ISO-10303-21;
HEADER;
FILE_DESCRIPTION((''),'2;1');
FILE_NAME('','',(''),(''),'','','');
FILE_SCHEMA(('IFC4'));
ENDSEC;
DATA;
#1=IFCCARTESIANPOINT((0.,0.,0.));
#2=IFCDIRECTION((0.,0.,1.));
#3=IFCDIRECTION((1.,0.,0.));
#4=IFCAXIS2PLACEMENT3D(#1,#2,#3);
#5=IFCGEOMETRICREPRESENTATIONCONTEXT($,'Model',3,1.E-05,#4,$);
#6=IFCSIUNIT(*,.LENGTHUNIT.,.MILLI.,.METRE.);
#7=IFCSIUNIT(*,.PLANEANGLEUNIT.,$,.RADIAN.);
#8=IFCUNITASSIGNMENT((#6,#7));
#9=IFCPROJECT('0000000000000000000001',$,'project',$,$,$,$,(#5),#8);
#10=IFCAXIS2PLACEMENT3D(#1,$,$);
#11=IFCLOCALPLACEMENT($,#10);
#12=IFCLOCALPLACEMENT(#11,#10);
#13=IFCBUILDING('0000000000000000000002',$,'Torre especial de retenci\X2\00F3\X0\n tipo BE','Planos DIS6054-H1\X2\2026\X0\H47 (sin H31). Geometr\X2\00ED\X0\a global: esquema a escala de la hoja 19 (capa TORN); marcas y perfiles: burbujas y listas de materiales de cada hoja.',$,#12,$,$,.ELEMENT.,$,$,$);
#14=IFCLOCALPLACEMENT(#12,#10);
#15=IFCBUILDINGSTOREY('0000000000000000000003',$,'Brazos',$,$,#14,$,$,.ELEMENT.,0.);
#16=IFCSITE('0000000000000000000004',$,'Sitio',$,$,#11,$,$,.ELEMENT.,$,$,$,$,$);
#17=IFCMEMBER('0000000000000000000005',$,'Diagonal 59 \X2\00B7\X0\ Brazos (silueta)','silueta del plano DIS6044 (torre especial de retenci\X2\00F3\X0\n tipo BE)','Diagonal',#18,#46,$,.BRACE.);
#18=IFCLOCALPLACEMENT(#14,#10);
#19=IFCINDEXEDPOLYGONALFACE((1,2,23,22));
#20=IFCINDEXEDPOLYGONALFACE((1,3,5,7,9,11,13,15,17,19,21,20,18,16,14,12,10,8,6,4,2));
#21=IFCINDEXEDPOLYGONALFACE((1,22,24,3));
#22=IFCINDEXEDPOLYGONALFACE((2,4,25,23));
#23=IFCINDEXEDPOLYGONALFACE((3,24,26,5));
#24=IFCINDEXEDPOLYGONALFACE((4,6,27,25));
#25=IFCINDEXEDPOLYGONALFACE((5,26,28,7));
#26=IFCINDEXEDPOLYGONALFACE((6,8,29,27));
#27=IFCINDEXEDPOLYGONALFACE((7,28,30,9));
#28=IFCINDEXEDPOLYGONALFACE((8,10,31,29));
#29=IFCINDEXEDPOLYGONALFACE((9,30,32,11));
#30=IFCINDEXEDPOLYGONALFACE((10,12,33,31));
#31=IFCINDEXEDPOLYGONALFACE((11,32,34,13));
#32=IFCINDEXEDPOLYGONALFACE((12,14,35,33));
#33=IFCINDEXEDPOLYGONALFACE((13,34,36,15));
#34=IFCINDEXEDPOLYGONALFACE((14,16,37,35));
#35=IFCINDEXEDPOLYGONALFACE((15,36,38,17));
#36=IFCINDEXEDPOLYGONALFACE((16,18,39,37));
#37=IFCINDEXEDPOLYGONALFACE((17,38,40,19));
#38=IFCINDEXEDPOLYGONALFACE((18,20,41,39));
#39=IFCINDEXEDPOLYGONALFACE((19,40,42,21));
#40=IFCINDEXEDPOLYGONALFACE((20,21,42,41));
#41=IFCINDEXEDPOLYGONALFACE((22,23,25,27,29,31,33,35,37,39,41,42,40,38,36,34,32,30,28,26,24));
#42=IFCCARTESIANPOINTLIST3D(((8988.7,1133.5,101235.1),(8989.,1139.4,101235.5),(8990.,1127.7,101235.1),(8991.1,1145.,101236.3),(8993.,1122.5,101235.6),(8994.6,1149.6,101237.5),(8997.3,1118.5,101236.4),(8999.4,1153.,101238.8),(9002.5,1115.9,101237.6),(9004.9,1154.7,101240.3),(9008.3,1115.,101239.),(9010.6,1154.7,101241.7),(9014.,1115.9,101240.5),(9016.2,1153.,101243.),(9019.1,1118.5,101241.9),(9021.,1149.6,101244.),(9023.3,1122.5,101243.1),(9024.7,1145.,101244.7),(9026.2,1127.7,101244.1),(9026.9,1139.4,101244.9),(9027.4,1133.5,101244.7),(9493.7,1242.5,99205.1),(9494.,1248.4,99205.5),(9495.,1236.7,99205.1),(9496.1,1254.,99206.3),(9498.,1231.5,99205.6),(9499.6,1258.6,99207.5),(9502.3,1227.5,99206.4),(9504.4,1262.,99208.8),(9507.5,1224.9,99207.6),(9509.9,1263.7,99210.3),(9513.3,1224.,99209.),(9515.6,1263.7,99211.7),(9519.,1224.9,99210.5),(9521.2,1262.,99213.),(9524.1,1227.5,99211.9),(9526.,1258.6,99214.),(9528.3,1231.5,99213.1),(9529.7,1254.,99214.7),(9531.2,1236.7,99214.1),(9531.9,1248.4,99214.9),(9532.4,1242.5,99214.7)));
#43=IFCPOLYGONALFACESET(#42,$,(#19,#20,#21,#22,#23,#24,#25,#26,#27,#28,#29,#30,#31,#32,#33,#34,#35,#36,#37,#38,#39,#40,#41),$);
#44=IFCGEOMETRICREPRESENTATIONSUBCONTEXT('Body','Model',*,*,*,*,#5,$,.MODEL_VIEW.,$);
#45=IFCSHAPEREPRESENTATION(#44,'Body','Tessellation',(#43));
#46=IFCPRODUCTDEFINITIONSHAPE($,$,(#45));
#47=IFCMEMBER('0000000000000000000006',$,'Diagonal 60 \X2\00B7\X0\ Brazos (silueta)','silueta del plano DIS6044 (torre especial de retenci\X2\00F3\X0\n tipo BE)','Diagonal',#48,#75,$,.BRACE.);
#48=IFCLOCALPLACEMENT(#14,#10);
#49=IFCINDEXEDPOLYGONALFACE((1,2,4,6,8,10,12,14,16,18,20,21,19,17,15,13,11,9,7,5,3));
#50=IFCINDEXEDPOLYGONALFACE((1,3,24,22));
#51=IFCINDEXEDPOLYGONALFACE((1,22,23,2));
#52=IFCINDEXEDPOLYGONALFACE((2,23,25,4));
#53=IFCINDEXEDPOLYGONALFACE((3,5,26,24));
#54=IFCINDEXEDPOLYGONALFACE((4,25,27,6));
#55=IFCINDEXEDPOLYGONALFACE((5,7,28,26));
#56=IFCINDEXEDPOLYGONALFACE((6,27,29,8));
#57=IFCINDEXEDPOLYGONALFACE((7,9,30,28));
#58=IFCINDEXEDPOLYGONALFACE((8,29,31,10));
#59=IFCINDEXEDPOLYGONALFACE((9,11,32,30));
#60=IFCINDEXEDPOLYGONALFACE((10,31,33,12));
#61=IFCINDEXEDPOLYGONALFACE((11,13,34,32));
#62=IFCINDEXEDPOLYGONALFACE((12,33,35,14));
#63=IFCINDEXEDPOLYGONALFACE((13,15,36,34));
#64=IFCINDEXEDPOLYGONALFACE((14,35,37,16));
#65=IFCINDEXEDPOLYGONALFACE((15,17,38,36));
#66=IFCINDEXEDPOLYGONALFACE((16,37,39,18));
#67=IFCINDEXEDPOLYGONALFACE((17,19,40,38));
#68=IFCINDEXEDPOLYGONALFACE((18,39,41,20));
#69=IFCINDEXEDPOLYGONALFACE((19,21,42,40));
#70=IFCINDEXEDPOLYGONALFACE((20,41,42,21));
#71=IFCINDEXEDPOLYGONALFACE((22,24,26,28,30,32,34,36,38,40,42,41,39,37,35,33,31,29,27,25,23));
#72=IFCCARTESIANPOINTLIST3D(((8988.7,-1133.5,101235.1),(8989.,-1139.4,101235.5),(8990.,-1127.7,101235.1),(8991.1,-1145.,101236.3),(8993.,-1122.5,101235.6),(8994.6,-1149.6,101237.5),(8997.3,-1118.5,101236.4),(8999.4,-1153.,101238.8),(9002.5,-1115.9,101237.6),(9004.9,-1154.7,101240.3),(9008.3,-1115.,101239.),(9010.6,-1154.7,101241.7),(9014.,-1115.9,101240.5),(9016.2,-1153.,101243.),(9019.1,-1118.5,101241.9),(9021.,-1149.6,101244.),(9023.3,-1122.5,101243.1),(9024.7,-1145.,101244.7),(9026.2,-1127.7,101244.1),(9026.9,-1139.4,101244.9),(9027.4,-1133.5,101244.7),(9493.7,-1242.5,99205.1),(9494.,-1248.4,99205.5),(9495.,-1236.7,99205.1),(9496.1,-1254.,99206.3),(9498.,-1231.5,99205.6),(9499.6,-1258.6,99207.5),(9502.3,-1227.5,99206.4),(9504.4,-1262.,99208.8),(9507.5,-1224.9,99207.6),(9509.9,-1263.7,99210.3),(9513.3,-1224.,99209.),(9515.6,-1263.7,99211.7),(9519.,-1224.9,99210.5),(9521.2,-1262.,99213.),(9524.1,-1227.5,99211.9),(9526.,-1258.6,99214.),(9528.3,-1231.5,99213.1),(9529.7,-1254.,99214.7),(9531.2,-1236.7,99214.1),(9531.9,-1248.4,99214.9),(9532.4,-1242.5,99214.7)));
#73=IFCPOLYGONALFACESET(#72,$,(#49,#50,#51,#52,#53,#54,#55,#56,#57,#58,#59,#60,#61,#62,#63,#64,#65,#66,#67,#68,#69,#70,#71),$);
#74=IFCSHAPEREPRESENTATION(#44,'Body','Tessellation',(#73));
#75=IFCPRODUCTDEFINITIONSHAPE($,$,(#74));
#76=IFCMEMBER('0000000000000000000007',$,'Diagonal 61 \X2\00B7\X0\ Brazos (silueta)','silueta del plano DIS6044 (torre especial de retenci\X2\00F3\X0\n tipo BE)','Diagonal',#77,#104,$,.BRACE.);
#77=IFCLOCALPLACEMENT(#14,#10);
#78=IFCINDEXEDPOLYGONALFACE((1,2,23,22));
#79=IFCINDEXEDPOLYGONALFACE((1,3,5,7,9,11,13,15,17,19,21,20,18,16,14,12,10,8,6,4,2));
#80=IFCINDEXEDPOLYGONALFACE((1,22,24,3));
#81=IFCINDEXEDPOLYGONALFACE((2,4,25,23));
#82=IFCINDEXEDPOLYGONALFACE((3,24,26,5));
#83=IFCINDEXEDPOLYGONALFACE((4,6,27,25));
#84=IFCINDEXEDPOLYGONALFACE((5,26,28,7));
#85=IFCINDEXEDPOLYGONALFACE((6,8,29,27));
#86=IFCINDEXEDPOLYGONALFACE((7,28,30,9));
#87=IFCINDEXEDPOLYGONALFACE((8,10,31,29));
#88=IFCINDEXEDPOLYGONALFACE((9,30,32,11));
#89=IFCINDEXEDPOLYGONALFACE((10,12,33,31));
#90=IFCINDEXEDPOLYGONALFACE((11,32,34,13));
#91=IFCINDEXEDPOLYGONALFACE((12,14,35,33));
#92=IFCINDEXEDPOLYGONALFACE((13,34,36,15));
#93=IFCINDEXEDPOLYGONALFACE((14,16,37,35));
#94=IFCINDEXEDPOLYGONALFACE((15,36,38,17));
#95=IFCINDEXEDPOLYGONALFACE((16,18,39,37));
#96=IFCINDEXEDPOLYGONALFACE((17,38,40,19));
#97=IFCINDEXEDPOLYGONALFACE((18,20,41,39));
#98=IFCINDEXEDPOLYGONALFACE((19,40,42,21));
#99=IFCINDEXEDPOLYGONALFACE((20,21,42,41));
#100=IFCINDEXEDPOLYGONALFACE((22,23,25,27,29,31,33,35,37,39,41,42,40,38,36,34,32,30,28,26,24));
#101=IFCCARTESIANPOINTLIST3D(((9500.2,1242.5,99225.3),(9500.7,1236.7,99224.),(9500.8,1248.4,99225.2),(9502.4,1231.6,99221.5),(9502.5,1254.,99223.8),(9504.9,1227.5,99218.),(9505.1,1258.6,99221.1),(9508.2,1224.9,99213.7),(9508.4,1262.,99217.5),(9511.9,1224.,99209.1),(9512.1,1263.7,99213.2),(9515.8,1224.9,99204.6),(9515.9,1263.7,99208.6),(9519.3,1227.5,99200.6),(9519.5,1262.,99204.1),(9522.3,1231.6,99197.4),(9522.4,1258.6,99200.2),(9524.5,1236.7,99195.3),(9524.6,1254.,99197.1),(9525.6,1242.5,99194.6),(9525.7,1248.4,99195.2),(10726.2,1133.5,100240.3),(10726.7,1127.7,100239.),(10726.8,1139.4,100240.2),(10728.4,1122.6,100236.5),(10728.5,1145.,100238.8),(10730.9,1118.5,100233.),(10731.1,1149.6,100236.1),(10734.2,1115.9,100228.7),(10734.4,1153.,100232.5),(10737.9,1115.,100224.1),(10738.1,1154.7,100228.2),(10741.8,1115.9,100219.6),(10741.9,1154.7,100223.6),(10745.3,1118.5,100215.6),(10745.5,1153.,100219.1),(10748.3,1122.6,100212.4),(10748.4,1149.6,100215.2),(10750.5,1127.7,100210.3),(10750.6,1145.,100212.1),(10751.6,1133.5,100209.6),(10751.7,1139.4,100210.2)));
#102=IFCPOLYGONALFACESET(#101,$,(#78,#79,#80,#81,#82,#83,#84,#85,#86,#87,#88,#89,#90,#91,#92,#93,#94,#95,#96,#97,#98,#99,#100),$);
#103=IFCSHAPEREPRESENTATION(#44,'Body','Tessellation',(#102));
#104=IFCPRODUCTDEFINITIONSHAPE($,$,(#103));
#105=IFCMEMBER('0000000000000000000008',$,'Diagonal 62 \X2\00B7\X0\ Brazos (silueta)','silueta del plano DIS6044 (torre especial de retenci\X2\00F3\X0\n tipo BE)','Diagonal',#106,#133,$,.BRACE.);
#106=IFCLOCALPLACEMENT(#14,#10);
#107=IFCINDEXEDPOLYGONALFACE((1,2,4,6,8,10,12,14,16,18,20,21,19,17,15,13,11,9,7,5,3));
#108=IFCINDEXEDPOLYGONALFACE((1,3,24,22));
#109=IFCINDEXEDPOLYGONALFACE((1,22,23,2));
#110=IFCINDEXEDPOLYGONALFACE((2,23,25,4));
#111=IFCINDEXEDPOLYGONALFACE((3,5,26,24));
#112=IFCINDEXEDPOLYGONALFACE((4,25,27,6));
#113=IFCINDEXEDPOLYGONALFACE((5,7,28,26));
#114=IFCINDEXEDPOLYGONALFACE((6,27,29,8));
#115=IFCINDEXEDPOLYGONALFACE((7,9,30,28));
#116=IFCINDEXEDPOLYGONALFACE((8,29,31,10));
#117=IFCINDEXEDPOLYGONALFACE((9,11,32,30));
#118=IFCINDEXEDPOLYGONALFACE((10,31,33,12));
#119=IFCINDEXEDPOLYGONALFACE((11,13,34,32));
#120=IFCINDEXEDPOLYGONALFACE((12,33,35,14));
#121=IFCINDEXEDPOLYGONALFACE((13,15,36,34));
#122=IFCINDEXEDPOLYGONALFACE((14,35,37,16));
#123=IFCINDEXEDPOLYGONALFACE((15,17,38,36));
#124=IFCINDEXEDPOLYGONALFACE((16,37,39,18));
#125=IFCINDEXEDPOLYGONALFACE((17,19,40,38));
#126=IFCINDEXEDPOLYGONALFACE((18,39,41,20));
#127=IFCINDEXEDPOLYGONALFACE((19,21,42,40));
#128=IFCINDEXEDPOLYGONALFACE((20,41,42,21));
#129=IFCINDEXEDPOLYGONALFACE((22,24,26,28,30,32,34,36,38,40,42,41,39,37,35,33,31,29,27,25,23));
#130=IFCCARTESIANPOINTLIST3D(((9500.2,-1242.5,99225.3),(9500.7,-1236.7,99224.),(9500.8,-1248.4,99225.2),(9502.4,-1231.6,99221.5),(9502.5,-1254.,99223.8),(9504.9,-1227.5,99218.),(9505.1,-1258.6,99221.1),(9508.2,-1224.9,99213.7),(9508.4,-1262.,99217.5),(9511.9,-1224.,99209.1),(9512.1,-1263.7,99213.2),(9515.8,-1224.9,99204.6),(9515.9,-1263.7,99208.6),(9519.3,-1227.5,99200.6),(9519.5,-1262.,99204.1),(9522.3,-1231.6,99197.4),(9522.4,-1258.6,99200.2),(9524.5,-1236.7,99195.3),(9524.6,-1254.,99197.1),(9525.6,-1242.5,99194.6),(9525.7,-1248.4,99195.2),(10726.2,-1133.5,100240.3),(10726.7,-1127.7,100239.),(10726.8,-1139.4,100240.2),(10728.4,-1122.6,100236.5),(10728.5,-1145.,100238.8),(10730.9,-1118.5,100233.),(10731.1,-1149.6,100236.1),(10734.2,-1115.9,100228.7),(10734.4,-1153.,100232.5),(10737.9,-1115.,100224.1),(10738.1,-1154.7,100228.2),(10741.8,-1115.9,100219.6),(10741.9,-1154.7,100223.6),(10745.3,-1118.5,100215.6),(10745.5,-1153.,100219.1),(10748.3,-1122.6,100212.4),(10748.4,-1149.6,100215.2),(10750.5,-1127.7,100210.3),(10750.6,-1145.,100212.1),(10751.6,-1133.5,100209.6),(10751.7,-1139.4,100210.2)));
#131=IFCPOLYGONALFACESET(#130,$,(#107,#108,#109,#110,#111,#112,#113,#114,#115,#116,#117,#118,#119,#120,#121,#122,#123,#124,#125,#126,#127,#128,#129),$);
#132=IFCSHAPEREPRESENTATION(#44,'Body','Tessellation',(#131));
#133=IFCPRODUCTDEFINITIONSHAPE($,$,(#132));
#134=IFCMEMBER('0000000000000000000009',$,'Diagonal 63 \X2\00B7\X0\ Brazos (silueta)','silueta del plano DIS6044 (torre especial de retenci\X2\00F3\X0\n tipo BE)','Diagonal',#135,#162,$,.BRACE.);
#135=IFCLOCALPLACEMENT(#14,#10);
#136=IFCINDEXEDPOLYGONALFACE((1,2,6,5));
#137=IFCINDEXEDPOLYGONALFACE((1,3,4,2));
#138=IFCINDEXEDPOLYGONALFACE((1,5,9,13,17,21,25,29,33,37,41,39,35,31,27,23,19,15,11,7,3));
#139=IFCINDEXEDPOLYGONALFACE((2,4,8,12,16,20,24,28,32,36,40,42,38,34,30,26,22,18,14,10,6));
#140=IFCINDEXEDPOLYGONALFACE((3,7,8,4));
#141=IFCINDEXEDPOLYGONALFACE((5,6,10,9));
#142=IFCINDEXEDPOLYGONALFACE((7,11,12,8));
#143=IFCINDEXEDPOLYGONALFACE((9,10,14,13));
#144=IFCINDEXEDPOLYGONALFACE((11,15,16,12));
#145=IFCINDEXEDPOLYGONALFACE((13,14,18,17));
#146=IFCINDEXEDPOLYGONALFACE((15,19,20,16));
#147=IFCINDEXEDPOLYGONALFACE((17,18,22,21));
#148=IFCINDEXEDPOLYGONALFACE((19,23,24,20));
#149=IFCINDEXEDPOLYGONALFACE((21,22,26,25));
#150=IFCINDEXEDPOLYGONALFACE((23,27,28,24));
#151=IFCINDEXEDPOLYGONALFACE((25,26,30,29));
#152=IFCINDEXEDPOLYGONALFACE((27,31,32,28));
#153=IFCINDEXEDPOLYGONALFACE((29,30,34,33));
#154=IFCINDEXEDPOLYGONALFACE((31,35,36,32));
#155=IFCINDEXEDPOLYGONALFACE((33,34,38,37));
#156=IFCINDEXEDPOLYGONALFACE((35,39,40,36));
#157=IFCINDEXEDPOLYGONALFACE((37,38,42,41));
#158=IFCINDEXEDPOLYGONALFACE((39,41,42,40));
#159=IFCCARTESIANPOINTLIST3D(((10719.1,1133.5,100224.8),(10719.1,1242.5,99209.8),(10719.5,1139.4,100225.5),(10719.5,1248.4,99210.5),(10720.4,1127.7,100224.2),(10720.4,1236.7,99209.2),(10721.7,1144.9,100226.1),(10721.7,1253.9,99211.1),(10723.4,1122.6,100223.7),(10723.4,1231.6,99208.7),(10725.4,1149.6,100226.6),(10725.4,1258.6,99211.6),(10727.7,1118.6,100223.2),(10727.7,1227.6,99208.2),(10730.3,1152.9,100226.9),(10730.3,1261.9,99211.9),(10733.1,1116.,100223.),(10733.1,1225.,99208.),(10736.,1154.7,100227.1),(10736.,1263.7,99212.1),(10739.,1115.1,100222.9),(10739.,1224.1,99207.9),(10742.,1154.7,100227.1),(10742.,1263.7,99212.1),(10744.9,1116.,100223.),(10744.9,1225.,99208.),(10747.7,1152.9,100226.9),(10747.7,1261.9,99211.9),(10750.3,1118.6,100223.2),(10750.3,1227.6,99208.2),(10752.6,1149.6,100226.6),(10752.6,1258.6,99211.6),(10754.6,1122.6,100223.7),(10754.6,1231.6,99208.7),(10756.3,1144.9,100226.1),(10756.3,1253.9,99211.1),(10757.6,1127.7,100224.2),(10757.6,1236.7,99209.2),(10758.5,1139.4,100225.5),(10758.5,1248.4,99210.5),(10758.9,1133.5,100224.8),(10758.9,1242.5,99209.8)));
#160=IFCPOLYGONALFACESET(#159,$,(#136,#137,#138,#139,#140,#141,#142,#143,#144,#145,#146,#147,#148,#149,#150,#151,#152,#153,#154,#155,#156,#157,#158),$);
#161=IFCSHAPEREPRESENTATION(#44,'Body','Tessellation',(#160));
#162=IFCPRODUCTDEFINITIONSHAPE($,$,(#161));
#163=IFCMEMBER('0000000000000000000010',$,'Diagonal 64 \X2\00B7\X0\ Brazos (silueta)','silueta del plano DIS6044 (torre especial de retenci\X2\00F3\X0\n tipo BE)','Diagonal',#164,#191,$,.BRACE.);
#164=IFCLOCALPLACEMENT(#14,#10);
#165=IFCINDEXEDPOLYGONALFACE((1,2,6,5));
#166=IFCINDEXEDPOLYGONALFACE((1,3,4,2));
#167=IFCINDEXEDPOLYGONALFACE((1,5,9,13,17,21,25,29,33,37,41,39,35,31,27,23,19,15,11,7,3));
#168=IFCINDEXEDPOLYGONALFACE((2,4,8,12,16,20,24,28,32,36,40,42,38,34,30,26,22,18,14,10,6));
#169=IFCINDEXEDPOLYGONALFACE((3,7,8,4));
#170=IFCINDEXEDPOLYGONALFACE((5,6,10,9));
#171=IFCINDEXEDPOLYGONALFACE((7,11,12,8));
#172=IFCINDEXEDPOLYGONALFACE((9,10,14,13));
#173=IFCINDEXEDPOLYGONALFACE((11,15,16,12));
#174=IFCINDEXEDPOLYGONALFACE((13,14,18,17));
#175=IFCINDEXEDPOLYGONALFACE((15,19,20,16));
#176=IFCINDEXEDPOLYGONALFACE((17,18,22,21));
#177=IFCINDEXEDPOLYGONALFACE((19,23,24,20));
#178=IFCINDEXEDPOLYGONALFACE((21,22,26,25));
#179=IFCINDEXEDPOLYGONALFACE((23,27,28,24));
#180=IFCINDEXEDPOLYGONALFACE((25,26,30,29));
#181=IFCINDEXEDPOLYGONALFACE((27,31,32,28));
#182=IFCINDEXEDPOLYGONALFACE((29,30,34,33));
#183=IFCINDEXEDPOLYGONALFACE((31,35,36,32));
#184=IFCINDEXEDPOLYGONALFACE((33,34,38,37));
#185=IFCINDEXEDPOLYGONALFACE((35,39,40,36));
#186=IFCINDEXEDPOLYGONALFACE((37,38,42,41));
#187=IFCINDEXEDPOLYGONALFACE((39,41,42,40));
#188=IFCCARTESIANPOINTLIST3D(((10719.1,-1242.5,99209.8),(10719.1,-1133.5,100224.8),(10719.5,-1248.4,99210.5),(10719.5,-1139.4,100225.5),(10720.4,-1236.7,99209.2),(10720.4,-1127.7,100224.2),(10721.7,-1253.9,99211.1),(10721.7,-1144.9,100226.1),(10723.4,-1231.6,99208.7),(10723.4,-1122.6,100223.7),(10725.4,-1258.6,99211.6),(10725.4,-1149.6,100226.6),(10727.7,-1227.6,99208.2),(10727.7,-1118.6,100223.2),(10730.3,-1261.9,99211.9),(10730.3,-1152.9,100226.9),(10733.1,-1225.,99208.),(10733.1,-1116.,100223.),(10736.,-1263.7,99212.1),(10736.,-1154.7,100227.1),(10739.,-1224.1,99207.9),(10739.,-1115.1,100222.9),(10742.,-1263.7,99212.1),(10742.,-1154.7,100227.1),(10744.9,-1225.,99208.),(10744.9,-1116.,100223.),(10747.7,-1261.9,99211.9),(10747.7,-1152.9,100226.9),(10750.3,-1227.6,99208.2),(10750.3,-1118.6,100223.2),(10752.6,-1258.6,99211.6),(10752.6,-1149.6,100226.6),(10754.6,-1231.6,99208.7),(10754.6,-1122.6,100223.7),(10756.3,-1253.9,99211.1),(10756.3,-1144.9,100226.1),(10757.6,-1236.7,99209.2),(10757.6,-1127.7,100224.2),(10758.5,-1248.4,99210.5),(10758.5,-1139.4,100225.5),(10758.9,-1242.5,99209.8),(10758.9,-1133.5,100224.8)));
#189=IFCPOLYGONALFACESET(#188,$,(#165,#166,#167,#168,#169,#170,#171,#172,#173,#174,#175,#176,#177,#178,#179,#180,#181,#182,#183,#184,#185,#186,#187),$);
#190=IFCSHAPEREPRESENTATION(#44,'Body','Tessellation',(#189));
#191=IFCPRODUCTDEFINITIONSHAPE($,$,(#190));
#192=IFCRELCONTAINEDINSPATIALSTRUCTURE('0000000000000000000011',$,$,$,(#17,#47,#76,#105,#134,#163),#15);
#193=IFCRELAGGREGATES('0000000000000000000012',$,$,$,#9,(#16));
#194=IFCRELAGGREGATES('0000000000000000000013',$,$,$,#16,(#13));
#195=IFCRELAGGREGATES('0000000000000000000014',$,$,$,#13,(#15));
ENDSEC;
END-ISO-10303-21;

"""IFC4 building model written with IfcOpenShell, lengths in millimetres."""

from ifc_helpers import new_model, si_unit, frame, origin, origin_with_axes, place, context, subcontext, project, spatial, circle, extrude, element, save


model = new_model("IFC4")

# Units and contexts
model_context = context("Model", 3, precision=1e-05, world=origin_with_axes())
body_context = subcontext(model_context, "Body", "Model", "MODEL_VIEW")
ifc_project = project(units=[si_unit("LENGTHUNIT", "METRE", prefix="MILLI"), si_unit("PLANEANGLEUNIT", "RADIAN")], contexts=[model_context])

# Site, building, storey
site_placement = place(None, origin())
site = spatial("IfcSite", under=ifc_project, at=site_placement, Name="Sitio", CompositionType="ELEMENT")
building_placement = place(site_placement, origin())
building = spatial("IfcBuilding", under=site, at=building_placement, Name="Torre especial de retención tipo BE", Description="Planos DIS6054-H1…H47 (sin H31). Geometría global: esquema a escala de la hoja 19 (capa TORN); marcas y perfiles: burbujas y listas de materiales de cada hoja.", CompositionType="ELEMENT")
storey_placement = place(building_placement, origin())
storey = spatial("IfcBuildingStorey", under=building, at=storey_placement, Name="Brazos", CompositionType="ELEMENT", Elevation=0.0)

# Members
for number, where, z_axis, x_axis, name in (
    (1, (9008.0, 1135.0, 101240.0), (0.241084, 0.052036, -0.969108), (0.012562, -0.998645, -0.050497), "Diagonal 59 · Brazos (silueta)"),
    (2, (9008.0, -1135.0, 101240.0), (0.241084, -0.052036, -0.969108), (0.012562, 0.998645, -0.050497), "Diagonal 60 · Brazos (silueta)"),
):
    element("IfcMember", number, at=place(storey_placement, frame(where, z_axis=z_axis, x_axis=x_axis)), inside=storey, Name=name, Description="silueta del plano DIS6044 (torre especial de retención tipo BE)", ObjectType="Diagonal", PredefinedType="BRACE", context=body_context, shape_type="SweptSolid", body=[
        extrude(circle(Radius=20.0), None, (0.0, 0.0, 1.0), 2094.7),
    ])
for number, where, z_axis, x_axis, name in (
    (3, (9513.0, 1244.0, 99210.0), (0.768477, -0.068323, 0.636219), (-0.052628, -0.997663, -0.04357), "Diagonal 61 · Brazos (silueta)"),
    (4, (9513.0, -1244.0, 99210.0), (0.768477, 0.068323, 0.636219), (-0.052628, 0.997663, -0.04357), "Diagonal 62 · Brazos (silueta)"),
):
    element("IfcMember", number, at=place(storey_placement, frame(where, z_axis=z_axis, x_axis=x_axis)), inside=storey, Name=name, Description="silueta del plano DIS6044 (torre especial de retención tipo BE)", ObjectType="Diagonal", PredefinedType="BRACE", context=body_context, shape_type="SweptSolid", body=[
        extrude(circle(Radius=20.0), None, (0.0, 0.0, 1.0), 1595.4),
    ])
for number, where, z_axis, x_axis, name in (
    (5, (10739.0, 1135.0, 100225.0), (0.0, 0.106775, -0.994283), (0.0, -0.994283, -0.106775), "Diagonal 63 · Brazos (silueta)"),
    (6, (10739.0, -1135.0, 100225.0), (0.0, -0.106775, -0.994283), (0.0, 0.994283, -0.106775), "Diagonal 64 · Brazos (silueta)"),
):
    element("IfcMember", number, at=place(storey_placement, frame(where, z_axis=z_axis, x_axis=x_axis)), inside=storey, Name=name, Description="silueta del plano DIS6044 (torre especial de retención tipo BE)", ObjectType="Diagonal", PredefinedType="BRACE", context=body_context, shape_type="SweptSolid", body=[
        extrude(circle(Radius=20.0), None, (0.0, 0.0, 1.0), 1020.8),
    ])

save(model, "model.ifc")
